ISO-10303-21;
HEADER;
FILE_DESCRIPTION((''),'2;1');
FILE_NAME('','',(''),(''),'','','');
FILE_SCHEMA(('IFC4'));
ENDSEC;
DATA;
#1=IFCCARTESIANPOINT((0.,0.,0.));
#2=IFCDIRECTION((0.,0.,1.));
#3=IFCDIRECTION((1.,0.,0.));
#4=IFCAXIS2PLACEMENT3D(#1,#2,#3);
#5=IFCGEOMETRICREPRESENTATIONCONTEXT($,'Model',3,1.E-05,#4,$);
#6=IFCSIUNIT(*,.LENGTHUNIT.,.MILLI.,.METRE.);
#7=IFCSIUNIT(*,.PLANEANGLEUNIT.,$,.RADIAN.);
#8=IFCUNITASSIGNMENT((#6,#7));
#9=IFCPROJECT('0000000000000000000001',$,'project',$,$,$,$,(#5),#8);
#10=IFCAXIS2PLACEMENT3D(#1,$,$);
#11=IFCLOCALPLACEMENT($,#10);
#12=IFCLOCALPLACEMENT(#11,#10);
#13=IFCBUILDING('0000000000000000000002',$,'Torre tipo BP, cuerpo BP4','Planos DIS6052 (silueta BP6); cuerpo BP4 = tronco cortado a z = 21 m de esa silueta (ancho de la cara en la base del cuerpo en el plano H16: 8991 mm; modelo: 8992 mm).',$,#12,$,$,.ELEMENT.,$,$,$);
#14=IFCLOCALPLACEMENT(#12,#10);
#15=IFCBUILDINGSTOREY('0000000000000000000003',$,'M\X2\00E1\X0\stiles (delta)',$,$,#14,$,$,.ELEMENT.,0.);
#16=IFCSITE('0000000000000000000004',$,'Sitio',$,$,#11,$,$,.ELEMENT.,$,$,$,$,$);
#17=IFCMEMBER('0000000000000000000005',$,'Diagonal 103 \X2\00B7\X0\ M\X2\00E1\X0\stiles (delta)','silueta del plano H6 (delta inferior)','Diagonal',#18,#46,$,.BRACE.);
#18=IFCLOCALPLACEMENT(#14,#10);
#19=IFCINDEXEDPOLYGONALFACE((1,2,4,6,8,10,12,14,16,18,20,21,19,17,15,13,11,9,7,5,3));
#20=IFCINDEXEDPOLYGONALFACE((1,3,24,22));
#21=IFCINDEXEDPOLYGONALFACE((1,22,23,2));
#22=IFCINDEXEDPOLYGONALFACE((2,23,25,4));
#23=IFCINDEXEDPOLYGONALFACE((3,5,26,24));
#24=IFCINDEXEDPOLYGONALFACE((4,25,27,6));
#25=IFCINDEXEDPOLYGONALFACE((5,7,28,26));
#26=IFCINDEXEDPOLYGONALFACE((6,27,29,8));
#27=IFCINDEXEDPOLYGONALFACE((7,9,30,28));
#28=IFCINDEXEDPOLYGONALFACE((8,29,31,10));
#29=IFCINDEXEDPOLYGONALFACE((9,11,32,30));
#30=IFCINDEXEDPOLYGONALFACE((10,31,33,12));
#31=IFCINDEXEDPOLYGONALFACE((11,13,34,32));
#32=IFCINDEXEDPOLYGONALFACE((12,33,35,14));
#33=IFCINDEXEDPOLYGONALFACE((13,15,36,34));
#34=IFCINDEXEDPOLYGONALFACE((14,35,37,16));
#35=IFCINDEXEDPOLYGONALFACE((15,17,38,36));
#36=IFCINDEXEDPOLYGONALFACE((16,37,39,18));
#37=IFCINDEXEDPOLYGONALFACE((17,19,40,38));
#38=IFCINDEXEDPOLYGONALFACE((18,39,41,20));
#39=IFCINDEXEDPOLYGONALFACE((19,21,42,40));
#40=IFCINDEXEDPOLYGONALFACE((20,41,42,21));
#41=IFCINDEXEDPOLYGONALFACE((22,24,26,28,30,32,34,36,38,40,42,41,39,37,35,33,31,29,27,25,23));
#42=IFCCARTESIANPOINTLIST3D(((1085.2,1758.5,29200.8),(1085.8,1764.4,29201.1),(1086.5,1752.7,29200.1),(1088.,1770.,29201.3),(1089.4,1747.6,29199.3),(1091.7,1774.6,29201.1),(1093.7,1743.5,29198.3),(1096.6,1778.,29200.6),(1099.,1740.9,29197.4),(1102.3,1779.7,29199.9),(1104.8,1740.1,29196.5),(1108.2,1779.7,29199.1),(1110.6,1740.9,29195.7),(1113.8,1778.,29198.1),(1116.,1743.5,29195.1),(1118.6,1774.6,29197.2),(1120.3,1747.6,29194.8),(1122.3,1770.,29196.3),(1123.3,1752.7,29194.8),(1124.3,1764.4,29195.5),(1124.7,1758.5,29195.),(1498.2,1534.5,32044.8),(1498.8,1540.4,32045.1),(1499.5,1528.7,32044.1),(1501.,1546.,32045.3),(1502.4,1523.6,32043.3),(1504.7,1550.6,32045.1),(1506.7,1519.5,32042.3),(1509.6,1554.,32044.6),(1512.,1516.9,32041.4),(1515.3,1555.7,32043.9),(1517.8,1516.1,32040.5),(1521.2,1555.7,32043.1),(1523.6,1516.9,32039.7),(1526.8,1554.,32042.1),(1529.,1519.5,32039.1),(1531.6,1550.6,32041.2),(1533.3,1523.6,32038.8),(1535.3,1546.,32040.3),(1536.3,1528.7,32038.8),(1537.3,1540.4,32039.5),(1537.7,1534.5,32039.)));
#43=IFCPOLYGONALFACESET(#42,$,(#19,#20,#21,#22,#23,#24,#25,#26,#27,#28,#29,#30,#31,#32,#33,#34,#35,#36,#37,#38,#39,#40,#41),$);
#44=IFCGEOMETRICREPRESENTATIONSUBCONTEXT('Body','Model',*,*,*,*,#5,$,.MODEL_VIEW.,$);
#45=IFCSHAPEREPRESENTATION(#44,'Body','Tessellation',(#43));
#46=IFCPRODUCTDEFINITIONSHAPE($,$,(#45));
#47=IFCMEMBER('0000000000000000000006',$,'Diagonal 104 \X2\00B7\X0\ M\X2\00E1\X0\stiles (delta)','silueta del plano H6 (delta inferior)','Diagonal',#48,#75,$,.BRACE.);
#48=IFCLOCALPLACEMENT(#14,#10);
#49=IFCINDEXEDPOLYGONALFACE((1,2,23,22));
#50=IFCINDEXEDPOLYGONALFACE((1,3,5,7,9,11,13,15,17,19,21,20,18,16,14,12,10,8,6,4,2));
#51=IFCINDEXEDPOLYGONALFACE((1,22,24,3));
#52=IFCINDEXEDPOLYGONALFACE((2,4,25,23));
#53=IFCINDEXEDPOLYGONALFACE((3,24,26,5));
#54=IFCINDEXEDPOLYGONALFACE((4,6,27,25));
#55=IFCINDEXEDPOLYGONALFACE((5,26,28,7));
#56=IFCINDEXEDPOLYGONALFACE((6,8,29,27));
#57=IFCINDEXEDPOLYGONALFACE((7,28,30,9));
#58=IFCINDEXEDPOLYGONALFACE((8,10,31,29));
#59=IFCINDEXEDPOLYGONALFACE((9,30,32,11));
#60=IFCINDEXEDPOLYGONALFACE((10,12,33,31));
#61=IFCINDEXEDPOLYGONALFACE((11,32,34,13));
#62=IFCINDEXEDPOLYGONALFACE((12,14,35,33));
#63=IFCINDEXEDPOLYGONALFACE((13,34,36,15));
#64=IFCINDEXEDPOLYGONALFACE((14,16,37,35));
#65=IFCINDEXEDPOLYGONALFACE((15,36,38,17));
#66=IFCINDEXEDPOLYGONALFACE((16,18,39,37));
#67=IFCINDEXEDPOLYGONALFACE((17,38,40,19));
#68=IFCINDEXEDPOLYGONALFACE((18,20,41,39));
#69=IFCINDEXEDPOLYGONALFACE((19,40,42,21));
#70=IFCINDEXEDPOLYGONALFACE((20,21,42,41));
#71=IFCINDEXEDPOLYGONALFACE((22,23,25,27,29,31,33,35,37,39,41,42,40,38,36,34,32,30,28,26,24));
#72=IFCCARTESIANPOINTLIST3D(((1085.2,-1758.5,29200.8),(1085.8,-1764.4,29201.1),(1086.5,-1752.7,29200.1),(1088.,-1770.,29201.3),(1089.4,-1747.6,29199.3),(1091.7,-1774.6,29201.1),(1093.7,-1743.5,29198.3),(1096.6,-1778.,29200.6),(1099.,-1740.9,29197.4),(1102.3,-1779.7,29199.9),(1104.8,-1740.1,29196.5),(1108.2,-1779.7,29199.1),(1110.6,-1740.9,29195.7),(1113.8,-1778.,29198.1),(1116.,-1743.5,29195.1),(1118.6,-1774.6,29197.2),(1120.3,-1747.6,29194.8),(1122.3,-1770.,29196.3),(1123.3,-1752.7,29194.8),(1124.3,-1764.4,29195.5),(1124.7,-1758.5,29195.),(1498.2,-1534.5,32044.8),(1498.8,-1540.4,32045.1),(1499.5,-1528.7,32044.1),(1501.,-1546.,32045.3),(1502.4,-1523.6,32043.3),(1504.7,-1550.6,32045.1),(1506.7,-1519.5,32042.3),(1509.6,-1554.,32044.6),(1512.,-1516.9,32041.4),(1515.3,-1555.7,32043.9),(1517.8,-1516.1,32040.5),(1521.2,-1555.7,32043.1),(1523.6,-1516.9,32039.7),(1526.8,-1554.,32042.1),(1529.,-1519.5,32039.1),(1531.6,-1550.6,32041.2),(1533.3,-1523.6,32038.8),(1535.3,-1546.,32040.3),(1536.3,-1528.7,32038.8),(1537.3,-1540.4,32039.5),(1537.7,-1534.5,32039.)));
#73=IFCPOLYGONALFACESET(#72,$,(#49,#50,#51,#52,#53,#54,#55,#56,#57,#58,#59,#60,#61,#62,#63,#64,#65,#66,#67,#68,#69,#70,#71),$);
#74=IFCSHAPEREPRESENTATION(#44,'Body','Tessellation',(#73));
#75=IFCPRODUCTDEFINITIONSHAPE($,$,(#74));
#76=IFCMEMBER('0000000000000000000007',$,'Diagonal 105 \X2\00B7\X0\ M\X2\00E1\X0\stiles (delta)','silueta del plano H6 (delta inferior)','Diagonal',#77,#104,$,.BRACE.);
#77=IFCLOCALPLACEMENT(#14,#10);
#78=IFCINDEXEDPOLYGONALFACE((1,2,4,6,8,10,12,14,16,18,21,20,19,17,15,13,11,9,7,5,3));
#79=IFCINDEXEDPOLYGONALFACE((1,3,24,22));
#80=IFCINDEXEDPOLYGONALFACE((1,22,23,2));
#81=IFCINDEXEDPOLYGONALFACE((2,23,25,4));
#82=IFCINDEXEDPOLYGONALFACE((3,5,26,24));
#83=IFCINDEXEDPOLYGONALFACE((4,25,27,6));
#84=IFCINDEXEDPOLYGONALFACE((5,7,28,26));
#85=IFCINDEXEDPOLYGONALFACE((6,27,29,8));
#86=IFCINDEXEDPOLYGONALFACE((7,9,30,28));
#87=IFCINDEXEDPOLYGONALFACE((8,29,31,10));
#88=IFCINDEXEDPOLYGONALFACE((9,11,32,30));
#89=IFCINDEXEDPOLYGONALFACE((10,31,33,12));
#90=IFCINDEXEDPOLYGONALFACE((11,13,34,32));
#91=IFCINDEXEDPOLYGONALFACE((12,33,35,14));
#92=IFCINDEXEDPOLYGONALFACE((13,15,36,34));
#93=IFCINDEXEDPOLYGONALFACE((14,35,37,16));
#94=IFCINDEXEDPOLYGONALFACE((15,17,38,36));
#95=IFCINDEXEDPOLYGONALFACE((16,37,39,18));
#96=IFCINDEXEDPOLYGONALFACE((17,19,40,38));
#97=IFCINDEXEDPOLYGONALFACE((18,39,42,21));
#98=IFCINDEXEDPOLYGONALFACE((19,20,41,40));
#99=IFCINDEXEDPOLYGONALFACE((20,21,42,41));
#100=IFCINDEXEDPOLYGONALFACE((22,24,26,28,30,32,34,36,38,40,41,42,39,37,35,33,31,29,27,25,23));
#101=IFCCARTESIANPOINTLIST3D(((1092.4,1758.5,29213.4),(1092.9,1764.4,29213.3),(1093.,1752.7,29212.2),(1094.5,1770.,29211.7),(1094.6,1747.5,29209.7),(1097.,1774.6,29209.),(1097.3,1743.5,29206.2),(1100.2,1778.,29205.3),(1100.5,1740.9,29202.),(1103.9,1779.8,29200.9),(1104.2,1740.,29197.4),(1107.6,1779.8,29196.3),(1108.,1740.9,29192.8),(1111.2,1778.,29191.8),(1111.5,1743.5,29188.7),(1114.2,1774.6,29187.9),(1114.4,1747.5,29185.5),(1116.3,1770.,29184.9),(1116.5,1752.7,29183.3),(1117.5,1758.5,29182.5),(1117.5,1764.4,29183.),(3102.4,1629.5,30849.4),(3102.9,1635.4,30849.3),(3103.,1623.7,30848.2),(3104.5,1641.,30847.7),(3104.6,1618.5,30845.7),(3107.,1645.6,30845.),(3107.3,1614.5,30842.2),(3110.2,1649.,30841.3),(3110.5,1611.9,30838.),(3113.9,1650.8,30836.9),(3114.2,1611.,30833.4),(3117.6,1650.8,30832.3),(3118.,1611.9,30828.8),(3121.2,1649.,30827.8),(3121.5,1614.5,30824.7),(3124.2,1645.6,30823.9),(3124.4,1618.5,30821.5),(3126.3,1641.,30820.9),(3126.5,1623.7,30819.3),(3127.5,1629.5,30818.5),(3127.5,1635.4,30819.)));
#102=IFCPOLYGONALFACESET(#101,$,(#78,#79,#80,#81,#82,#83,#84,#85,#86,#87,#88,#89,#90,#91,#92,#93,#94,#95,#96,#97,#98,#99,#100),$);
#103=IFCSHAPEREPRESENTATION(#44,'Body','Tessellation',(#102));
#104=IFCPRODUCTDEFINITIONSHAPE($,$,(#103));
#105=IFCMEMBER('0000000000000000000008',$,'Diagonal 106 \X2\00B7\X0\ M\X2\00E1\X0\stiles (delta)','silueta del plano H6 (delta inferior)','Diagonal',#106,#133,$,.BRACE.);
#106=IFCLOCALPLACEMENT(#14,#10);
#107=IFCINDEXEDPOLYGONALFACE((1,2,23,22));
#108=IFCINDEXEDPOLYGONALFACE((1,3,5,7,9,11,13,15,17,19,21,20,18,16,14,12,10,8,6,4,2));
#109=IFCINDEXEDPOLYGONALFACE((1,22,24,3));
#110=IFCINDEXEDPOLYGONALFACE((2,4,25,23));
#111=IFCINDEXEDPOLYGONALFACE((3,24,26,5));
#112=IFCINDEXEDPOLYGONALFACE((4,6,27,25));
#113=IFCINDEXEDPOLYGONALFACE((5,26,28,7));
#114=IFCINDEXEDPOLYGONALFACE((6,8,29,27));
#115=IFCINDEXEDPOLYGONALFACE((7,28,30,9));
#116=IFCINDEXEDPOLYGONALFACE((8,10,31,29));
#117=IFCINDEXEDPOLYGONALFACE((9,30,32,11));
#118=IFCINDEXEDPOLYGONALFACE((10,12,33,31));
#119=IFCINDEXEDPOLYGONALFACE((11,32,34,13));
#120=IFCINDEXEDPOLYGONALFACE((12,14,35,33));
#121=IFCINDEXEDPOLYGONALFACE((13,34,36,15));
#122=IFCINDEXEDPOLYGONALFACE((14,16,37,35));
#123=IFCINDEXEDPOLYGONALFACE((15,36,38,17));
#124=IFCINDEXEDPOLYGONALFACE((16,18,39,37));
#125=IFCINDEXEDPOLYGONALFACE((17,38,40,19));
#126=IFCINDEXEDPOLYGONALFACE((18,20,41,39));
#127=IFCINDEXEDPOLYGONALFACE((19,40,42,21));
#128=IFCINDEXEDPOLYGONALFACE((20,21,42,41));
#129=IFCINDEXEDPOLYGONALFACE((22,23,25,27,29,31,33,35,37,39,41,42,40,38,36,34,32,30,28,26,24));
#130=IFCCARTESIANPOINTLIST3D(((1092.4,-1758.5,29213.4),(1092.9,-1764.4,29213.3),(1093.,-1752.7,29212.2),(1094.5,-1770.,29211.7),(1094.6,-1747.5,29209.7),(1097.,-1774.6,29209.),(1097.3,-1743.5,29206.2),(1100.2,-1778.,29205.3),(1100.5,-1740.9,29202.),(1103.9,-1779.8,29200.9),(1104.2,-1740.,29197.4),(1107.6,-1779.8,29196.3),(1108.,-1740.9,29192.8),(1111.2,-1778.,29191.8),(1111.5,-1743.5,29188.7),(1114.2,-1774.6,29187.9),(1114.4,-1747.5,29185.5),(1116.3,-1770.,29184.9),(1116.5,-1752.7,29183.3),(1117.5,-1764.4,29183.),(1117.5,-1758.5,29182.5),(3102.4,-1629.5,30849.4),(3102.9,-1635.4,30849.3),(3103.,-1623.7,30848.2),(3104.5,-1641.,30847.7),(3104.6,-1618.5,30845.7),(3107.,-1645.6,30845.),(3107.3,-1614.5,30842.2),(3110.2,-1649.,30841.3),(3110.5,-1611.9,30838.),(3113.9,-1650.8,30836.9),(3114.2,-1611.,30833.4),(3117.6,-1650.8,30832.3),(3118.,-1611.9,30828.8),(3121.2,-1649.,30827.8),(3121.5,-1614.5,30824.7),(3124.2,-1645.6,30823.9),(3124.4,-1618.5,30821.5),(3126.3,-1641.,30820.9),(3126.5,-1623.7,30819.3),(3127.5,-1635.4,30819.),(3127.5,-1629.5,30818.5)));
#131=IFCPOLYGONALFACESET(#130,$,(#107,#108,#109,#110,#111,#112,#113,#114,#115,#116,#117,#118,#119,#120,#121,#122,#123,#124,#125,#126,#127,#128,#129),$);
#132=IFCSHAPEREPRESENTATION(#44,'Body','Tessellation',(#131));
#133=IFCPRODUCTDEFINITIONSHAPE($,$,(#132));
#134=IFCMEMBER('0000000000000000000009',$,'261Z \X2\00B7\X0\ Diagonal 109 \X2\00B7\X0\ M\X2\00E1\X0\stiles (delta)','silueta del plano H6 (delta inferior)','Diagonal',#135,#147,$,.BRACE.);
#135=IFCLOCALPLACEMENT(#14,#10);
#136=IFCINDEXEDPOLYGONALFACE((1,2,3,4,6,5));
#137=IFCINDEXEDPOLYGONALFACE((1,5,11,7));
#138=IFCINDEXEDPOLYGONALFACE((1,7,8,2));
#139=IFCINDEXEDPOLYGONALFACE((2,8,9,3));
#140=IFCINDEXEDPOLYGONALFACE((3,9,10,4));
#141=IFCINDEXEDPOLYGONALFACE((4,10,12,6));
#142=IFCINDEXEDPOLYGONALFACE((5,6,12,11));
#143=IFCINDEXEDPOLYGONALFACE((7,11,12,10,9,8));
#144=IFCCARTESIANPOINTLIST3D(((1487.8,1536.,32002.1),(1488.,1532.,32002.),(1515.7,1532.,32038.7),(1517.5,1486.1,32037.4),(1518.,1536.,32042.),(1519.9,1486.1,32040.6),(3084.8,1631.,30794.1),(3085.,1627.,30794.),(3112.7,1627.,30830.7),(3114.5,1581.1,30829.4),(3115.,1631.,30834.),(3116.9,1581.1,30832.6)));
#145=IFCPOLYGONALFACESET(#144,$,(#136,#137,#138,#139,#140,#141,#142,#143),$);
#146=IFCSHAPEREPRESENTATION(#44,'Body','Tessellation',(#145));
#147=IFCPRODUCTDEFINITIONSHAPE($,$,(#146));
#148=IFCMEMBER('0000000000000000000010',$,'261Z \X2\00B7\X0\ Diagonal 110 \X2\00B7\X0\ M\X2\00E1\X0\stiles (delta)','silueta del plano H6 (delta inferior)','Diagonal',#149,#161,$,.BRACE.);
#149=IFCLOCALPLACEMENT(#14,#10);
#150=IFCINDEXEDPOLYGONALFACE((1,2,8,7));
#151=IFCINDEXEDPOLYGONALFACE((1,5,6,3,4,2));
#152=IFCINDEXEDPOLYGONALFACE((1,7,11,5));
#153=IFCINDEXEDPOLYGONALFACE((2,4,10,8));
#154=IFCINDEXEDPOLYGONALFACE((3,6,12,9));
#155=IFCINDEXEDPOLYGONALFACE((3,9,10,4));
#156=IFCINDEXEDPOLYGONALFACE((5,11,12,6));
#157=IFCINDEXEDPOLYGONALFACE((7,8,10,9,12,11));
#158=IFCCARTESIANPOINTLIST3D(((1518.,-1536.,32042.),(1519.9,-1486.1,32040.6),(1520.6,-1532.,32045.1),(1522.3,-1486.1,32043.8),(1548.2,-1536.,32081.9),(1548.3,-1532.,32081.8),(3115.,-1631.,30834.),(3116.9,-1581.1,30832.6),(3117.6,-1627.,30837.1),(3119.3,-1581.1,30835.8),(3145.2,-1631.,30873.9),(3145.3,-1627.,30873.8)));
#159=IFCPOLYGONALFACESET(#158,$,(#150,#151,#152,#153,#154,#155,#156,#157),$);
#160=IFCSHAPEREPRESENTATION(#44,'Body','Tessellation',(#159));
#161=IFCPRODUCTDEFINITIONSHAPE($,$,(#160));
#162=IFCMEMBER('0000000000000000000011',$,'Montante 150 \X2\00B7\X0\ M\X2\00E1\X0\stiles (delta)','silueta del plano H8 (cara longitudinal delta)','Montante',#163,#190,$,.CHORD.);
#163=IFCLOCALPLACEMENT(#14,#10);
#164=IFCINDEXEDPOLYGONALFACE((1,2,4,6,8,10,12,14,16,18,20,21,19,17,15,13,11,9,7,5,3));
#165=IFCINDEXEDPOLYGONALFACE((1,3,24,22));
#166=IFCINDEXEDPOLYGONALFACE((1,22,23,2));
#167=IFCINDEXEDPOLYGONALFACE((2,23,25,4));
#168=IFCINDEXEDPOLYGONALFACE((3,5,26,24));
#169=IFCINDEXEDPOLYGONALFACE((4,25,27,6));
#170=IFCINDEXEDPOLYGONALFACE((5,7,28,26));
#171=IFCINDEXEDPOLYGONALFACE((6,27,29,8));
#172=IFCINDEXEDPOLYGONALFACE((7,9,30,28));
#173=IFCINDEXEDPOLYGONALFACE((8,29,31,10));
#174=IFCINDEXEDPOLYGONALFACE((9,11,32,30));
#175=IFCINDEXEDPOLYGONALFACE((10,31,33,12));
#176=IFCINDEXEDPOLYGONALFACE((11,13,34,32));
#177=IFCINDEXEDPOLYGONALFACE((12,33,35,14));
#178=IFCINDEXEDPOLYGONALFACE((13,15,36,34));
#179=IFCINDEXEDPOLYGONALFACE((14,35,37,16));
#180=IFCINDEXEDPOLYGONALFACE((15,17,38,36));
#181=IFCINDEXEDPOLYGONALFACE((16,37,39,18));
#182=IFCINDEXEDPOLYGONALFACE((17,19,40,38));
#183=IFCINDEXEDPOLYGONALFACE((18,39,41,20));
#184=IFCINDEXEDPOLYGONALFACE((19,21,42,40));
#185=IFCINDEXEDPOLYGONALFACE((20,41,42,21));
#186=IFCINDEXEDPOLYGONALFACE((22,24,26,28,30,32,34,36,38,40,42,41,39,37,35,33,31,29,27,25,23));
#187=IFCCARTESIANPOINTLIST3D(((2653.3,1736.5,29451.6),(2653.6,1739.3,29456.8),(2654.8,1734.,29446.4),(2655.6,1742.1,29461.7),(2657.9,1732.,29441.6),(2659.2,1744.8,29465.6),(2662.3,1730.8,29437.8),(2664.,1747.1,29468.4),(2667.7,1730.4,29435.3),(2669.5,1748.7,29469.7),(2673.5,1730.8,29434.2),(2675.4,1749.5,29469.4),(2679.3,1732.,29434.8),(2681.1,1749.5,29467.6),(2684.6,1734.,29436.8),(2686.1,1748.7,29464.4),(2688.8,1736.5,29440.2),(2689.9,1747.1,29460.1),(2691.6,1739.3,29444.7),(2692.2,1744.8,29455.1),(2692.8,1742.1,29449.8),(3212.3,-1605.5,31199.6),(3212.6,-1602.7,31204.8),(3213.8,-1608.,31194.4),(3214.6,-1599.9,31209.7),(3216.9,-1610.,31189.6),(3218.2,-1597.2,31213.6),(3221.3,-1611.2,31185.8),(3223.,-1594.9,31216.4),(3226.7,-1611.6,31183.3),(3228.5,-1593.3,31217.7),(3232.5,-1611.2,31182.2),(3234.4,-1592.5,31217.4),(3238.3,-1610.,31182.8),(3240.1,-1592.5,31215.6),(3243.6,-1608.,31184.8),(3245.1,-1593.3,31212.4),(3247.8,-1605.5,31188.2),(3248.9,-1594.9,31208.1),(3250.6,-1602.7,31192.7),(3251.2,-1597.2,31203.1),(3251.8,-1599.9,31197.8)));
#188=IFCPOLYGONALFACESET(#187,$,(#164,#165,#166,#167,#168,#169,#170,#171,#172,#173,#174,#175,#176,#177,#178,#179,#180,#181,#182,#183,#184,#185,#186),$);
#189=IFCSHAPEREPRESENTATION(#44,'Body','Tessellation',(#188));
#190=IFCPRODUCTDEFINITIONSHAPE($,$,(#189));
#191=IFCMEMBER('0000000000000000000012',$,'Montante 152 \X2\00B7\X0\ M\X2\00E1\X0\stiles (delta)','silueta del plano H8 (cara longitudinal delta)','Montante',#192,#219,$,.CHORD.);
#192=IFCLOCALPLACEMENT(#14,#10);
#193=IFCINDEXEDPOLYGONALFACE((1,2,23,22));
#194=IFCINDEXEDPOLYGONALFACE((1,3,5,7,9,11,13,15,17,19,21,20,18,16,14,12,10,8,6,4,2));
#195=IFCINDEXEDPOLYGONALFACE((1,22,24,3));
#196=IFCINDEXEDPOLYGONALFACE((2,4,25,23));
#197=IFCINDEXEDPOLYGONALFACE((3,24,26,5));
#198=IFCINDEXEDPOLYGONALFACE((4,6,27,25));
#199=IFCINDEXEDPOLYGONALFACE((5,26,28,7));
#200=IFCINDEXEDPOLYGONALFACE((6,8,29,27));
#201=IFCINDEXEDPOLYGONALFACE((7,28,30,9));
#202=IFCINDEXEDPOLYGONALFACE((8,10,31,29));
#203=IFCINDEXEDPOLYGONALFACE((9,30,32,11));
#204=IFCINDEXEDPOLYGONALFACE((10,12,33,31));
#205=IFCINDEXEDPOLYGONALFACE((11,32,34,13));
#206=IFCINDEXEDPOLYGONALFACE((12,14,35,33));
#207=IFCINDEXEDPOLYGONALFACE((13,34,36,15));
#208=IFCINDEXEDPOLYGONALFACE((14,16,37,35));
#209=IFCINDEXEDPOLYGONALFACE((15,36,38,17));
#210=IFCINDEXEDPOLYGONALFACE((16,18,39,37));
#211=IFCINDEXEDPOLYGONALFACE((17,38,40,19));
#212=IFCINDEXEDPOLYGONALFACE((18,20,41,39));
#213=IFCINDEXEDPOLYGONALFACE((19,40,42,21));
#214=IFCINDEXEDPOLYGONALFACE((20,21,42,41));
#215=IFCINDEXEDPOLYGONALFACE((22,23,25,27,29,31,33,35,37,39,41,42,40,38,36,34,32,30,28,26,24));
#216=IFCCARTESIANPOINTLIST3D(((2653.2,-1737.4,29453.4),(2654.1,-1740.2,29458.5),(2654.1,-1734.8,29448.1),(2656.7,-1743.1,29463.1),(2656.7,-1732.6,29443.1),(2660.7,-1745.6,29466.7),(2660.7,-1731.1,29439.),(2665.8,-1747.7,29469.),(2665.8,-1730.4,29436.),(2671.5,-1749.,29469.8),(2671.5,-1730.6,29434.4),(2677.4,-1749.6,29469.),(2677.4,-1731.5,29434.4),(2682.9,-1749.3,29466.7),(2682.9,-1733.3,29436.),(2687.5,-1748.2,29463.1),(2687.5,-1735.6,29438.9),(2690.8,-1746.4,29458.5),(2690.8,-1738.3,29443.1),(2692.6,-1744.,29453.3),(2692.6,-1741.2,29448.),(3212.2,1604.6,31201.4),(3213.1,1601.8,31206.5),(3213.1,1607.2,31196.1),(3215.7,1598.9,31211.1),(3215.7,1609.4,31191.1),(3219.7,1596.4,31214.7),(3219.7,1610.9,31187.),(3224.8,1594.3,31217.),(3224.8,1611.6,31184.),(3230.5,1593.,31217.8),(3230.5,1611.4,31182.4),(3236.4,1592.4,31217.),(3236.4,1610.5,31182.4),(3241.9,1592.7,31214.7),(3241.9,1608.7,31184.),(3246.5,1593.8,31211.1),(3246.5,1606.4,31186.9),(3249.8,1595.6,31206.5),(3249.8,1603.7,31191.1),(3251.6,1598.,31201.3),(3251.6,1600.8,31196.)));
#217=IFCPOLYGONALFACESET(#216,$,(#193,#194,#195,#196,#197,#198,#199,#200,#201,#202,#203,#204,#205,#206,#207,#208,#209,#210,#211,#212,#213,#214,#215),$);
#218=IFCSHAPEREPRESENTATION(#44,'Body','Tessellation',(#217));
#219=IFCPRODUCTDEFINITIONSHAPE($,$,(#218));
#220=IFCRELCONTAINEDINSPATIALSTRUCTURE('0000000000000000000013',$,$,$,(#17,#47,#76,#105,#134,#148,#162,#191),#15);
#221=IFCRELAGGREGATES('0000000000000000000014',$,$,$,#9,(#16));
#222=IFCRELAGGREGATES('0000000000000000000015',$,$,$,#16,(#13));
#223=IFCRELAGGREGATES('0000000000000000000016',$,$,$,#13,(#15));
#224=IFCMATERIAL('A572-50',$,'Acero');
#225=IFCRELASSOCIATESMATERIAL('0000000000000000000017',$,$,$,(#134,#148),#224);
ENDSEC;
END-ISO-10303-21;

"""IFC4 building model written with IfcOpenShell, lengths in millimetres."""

from ifc_helpers import new_model, si_unit, frame, frame_2d, origin, origin_with_axes, place, context, subcontext, project, spatial, circle, l_section, extrude, material, element, save


model = new_model("IFC4")

# Units and contexts
model_context = context("Model", 3, precision=1e-05, world=origin_with_axes())
body_context = subcontext(model_context, "Body", "Model", "MODEL_VIEW")
ifc_project = project(units=[si_unit("LENGTHUNIT", "METRE", prefix="MILLI"), si_unit("PLANEANGLEUNIT", "RADIAN")], contexts=[model_context])

# Site, building, storey
site_placement = place(None, origin())
site = spatial("IfcSite", under=ifc_project, at=site_placement, Name="Sitio", CompositionType="ELEMENT")
building_placement = place(site_placement, origin())
building = spatial("IfcBuilding", under=site, at=building_placement, Name="Torre tipo BP, cuerpo BP4", Description="Planos DIS6052 (silueta BP6); cuerpo BP4 = tronco cortado a z = 21 m de esa silueta (ancho de la cara en la base del cuerpo en el plano H16: 8991 mm; modelo: 8992 mm).", CompositionType="ELEMENT")
storey_placement = place(building_placement, origin())
storey = spatial("IfcBuildingStorey", under=building, at=storey_placement, Name="Mástiles (delta)", CompositionType="ELEMENT", Elevation=0.0)

# Members
ifc_material = material(Name="A572-50", Category="Acero")
for number, where, z_axis, x_axis, name in (
    (1, (1518.0, 1536.0, 32042.0), (-0.143276, 0.077709, -0.986627), (-0.011168, -0.996976, -0.076902), "Diagonal 103 · Mástiles (delta)"),
    (2, (1518.0, -1536.0, 32042.0), (-0.143276, -0.077709, -0.986627), (-0.011168, 0.996976, -0.076902), "Diagonal 104 · Mástiles (delta)"),
):
    element("IfcMember", number, at=place(storey_placement, frame(where, z_axis=z_axis, x_axis=x_axis)), inside=storey, Name=name, Description="silueta del plano H6 (delta inferior)", ObjectType="Diagonal", PredefinedType="BRACE", context=body_context, shape_type="SweptSolid", body=[
        extrude(circle(Radius=20.0), None, (0.0, 0.0, 1.0), 2882.5),
    ])
for number, where, z_axis, x_axis, name in (
    (3, (1105.0, 1760.0, 29198.0), (0.774612, -0.049714, 0.63048), (-0.038557, -0.998764, -0.031382), "Diagonal 105 · Mástiles (delta)"),
    (4, (1105.0, -1760.0, 29198.0), (0.774612, 0.049714, 0.63048), (-0.038557, 0.998764, -0.031382), "Diagonal 106 · Mástiles (delta)"),
):
    element("IfcMember", number, at=place(storey_placement, frame(where, z_axis=z_axis, x_axis=x_axis)), inside=storey, Name=name, Description="silueta del plano H6 (delta inferior)", ObjectType="Diagonal", PredefinedType="BRACE", context=body_context, shape_type="SweptSolid", body=[
        extrude(circle(Radius=20.0), None, (0.0, 0.0, 1.0), 2594.8),
    ])
for number, where, z_axis, x_axis, name in (
    (5, (1518.0, 1536.0, 32042.0), (0.79664, 0.047389, -0.602593), (0.037795, -0.998876, -0.028589), "261Z · Diagonal 109 · Mástiles (delta)"),
    (6, (1518.0, -1536.0, 32042.0), (0.79664, -0.047389, -0.602593), (0.037795, 0.998876, -0.028589), "261Z · Diagonal 110 · Mástiles (delta)"),
):
    element("IfcMember", number, at=place(storey_placement, frame(where, z_axis=z_axis, x_axis=x_axis)), inside=storey, material=ifc_material, Name=name, Description="silueta del plano H6 (delta inferior)", ObjectType="Diagonal", PredefinedType="BRACE", context=body_context, shape_type="SweptSolid", body=[
        extrude(l_section(Depth=50.0, Width=50.0, Thickness=4.0, at=frame_2d((25.0, 25.0))), None, (0.0, 0.0, 1.0), 2004.7),
    ])
for number, where, z_axis, x_axis, name in (
    (7, (3232.0, -1602.0, 31200.0), (-0.146614, 0.876536, -0.458464), (-0.266991, -0.481336, -0.834884), "Montante 150 · Mástiles (delta)"),
    (8, (3232.0, 1602.0, 31200.0), (-0.146614, -0.876536, -0.458464), (-0.989194, 0.129916, 0.067951), "Montante 152 · Mástiles (delta)"),
):
    element("IfcMember", number, at=place(storey_placement, frame(where, z_axis=z_axis, x_axis=x_axis)), inside=storey, Name=name, Description="silueta del plano H8 (cara longitudinal delta)", ObjectType="Montante", PredefinedType="CHORD", context=body_context, shape_type="SweptSolid", body=[
        extrude(circle(Radius=20.0), None, (0.0, 0.0, 1.0), 3812.7),
    ])

save(model, "model.ifc")
